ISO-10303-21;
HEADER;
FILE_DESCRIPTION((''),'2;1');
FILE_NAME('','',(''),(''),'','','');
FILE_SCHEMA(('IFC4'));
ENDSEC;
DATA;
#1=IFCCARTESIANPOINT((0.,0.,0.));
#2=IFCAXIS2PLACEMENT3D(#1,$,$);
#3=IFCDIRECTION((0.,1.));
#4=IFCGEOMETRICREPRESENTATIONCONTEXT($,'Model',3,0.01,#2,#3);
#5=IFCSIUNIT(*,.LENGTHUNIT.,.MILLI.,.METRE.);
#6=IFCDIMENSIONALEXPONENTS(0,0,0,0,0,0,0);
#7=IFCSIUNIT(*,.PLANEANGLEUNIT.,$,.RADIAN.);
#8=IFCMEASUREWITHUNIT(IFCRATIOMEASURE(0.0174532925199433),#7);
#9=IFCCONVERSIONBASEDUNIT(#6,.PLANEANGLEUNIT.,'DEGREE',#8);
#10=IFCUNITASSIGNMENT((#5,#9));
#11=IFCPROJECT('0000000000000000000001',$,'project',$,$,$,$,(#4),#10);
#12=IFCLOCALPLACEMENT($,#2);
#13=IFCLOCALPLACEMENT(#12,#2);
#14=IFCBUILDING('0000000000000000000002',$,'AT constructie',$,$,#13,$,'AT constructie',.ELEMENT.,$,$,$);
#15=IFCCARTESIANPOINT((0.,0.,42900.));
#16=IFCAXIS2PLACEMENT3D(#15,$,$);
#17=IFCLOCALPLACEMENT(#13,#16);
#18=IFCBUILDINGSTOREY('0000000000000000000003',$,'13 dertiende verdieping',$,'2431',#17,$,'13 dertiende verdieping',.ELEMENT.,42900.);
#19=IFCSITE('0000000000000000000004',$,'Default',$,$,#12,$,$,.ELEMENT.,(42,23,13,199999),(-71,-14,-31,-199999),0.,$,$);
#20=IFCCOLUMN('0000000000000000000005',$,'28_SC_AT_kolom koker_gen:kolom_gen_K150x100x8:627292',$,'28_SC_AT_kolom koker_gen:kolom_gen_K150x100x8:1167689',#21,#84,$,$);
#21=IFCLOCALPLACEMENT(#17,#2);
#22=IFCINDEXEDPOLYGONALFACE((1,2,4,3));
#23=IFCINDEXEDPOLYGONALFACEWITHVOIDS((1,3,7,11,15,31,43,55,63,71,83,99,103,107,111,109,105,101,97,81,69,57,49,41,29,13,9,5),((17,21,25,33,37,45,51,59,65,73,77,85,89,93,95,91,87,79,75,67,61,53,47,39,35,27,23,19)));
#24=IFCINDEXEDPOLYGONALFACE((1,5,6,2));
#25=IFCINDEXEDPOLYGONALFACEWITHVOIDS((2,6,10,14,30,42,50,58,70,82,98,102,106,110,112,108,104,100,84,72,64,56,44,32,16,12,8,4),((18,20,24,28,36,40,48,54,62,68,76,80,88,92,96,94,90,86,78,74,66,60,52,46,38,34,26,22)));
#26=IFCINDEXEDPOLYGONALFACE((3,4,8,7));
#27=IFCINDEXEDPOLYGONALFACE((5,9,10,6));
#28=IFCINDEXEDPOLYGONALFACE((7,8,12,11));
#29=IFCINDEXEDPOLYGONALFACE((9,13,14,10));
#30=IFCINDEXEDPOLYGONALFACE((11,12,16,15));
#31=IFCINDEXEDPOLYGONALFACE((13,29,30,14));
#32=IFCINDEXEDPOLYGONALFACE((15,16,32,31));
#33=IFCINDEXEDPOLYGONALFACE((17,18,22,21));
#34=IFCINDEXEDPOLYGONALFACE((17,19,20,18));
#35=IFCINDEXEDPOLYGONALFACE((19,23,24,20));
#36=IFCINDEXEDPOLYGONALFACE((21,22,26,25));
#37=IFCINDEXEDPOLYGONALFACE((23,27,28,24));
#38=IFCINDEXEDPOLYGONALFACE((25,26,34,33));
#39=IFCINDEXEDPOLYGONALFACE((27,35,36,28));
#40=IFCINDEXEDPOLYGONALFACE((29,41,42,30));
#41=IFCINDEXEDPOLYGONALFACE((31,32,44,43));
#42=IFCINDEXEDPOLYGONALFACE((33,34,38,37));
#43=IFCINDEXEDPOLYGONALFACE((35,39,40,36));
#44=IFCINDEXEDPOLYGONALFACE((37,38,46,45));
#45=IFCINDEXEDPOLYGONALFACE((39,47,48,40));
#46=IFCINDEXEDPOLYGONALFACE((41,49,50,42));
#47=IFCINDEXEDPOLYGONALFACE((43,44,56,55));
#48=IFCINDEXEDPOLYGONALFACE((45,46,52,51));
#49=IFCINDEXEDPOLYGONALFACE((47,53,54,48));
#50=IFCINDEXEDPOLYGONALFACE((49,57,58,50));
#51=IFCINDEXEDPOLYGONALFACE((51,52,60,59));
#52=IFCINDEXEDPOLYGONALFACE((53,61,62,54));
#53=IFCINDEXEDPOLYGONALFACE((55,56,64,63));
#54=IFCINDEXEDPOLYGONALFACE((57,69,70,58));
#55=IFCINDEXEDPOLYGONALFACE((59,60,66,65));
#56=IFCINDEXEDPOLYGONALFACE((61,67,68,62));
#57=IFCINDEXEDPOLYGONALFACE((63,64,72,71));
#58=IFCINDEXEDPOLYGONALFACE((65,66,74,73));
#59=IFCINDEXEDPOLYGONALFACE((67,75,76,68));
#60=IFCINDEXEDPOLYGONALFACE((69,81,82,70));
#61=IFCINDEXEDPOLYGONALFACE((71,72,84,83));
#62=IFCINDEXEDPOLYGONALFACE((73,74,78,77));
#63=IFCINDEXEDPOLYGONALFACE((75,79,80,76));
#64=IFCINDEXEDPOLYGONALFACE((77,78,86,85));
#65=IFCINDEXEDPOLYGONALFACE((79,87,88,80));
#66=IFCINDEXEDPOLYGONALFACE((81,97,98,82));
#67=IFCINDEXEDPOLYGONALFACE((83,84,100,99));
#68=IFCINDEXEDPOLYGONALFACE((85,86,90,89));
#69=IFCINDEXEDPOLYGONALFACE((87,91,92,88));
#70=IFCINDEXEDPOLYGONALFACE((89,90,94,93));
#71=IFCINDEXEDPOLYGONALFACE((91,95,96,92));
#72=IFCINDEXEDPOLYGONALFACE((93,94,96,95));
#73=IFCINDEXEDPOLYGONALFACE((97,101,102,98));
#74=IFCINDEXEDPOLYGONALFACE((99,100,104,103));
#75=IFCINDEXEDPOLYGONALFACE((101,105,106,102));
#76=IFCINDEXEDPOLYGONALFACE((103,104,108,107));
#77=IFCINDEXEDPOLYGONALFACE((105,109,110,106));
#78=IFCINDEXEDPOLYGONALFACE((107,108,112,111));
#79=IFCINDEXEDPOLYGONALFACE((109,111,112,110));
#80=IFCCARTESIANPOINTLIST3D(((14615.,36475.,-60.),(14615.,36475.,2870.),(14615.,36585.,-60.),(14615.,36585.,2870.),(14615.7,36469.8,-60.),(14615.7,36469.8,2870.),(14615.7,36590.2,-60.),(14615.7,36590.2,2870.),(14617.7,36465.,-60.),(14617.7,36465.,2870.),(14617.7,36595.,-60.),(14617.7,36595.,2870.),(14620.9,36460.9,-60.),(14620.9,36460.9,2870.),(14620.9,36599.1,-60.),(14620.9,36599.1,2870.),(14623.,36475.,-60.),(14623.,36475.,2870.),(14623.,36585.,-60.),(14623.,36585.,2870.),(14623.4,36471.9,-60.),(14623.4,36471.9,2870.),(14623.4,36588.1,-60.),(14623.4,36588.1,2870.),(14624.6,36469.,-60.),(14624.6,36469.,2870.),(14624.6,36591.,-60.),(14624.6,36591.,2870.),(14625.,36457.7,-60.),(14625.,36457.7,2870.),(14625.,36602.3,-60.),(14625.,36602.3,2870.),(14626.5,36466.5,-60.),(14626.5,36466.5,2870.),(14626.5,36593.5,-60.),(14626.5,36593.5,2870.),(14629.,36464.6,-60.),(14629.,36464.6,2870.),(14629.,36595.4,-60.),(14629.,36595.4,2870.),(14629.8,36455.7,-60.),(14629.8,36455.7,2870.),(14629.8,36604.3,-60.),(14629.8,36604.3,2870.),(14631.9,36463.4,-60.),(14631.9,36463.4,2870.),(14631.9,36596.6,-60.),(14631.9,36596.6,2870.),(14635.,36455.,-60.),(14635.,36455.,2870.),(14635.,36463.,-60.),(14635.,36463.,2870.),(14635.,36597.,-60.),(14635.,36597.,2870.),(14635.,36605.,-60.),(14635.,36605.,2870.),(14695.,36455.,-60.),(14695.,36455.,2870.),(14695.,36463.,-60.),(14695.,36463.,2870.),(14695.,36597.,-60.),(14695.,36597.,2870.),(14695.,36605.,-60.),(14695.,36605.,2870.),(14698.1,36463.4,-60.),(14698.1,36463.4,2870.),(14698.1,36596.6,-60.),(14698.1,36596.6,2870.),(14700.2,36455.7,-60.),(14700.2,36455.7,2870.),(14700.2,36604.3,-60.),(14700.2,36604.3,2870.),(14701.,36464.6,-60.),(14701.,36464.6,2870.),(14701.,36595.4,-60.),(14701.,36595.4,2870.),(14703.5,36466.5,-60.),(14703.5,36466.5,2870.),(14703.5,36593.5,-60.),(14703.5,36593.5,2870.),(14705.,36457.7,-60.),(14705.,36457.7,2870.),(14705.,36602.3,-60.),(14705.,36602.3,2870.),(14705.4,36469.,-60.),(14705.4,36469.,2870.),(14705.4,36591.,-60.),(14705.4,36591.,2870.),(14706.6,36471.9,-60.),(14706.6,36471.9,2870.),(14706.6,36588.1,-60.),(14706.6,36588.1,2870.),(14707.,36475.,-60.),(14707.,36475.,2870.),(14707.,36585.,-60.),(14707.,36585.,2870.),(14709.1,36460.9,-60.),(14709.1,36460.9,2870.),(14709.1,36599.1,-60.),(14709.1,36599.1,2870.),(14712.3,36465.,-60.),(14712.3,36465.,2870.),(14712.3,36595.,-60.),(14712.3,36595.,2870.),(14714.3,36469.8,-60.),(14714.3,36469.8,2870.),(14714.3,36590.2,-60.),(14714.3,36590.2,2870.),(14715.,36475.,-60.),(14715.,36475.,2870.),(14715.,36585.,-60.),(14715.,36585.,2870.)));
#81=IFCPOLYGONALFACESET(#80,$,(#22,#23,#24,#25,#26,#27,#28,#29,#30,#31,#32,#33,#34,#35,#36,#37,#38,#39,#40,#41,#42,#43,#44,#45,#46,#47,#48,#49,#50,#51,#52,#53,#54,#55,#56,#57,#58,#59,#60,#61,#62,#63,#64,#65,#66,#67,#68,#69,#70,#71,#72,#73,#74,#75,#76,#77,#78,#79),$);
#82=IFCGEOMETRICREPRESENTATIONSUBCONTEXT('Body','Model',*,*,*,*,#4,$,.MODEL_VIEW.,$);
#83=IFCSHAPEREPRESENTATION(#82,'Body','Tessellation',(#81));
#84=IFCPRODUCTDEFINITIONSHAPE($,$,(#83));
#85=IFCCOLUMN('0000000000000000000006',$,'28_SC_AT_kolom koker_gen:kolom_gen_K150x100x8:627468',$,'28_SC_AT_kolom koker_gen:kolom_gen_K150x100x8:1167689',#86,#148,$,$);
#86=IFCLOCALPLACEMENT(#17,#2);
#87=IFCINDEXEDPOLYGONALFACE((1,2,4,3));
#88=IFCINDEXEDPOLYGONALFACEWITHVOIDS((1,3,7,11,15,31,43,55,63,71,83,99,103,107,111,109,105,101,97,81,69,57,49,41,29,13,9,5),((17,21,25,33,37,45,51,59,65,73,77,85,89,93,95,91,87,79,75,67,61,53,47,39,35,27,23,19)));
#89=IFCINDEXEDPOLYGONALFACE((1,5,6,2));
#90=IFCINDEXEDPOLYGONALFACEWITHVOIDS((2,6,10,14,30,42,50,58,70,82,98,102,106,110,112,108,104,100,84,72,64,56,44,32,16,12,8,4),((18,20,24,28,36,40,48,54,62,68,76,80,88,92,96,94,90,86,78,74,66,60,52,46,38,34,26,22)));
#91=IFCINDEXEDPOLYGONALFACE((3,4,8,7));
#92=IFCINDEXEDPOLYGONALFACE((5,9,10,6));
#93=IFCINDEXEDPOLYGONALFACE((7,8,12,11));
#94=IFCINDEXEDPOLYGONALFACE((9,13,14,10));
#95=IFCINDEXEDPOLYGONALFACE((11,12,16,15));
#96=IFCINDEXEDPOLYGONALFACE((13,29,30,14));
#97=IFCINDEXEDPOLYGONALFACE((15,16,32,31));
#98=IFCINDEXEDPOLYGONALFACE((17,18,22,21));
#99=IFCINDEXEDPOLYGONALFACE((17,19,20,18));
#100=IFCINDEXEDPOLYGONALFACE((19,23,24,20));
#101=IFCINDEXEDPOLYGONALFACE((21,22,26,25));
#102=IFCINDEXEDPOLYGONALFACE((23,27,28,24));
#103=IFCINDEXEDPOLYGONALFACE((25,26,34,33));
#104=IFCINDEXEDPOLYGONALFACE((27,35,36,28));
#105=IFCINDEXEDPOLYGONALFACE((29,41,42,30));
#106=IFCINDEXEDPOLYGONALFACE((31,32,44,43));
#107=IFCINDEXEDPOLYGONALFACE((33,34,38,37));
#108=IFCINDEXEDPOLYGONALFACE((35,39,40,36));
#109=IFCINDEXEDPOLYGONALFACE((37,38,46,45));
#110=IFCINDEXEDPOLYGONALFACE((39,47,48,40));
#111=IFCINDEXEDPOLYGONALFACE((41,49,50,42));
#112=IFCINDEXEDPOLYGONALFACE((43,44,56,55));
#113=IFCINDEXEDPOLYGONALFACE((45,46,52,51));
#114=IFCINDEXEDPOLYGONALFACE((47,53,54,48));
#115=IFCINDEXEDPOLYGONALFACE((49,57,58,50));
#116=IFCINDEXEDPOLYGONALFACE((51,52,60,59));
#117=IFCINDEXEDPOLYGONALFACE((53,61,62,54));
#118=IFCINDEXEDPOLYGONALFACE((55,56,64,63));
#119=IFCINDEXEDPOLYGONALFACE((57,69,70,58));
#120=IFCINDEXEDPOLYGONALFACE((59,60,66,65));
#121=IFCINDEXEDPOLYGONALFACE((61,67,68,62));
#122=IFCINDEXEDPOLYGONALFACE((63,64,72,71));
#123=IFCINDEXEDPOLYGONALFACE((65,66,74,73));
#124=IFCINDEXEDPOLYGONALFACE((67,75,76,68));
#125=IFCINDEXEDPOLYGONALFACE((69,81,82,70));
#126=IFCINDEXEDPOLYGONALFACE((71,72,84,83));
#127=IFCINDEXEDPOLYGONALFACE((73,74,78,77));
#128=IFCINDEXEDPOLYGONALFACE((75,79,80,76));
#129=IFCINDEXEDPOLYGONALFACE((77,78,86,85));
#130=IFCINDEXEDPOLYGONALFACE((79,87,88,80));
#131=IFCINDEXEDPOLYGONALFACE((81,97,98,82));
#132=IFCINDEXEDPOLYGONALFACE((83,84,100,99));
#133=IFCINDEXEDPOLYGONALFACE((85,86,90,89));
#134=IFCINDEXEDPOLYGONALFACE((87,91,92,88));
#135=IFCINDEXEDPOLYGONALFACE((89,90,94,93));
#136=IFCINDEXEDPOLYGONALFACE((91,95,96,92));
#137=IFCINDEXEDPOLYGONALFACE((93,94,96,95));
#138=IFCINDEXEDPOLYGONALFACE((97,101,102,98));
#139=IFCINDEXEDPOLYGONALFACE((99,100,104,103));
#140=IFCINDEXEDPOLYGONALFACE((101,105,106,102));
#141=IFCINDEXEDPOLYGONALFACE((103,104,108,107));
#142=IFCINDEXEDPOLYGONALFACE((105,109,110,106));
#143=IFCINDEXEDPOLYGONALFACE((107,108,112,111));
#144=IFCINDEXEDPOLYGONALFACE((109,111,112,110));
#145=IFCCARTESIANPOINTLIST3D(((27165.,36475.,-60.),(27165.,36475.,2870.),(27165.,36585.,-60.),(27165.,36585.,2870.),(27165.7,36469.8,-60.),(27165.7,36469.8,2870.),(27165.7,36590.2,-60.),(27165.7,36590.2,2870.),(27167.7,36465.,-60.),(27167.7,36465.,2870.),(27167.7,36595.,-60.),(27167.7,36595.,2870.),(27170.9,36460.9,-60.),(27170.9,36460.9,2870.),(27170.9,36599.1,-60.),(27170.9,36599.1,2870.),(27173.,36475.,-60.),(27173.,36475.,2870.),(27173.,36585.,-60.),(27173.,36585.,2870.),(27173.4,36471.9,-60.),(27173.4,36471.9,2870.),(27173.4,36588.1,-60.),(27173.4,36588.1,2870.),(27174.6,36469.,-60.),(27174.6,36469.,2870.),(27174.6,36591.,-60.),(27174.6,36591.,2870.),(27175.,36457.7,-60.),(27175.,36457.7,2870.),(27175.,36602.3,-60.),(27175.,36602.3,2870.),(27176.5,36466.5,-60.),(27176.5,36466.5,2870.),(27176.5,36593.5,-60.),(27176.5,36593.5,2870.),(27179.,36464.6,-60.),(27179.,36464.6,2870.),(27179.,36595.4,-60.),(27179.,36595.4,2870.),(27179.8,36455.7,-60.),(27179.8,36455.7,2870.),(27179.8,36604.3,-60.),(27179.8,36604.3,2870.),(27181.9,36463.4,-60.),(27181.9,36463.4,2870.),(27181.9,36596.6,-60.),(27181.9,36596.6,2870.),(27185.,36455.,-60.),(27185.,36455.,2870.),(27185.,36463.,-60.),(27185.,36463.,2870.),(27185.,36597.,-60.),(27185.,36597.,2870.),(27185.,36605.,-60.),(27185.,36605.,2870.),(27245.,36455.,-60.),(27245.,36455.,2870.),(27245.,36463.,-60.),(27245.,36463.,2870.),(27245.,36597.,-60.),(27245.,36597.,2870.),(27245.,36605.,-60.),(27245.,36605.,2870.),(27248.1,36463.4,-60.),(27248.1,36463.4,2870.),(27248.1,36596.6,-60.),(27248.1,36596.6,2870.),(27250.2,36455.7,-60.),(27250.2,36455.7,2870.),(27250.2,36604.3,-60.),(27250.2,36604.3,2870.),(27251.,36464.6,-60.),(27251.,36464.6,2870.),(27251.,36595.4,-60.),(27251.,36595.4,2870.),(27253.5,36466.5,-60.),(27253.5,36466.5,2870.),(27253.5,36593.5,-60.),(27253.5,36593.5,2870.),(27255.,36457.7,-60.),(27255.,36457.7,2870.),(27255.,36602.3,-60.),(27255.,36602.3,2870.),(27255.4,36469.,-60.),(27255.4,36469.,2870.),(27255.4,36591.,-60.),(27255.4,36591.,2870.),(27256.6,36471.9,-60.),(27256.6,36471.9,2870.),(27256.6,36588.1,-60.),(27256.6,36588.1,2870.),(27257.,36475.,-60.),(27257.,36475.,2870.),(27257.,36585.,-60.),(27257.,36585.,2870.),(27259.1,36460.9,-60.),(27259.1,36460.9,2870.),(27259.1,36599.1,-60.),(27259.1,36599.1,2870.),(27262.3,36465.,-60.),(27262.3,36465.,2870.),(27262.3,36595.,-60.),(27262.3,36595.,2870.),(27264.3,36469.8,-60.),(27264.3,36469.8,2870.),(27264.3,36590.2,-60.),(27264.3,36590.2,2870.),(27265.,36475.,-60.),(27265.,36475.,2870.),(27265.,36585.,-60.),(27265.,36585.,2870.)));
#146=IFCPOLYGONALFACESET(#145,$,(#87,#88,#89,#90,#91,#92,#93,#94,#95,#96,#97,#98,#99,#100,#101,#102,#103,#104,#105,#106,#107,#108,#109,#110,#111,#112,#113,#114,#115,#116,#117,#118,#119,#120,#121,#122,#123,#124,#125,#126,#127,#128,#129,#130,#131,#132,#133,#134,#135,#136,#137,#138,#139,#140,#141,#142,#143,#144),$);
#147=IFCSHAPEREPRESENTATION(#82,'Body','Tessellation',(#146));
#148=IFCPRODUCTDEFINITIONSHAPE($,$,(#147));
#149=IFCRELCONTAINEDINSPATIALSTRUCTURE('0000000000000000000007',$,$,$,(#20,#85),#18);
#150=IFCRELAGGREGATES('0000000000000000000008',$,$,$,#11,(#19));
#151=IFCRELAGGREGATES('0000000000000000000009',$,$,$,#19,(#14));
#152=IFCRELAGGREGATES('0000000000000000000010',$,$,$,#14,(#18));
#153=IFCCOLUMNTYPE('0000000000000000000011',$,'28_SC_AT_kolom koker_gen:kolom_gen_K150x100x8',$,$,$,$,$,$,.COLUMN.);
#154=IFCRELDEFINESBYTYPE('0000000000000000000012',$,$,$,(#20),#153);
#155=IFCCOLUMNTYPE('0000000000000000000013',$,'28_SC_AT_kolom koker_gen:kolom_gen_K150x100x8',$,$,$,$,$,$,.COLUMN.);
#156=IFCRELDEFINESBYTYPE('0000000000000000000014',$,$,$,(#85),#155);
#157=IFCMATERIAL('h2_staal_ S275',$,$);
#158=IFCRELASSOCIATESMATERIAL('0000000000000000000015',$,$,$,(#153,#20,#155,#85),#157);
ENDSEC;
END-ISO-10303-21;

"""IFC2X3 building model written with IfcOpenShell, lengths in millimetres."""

from ifc_helpers import new_model, entity, si_unit, converted_unit, direction, frame, frame_2d, origin, place, context, subcontext, project, spatial, polyline, circle_curve, parameter, trimmed, segment, composite_curve, outline, extrude, source, transform, mapped, material, type_object, type_shapes, element, save


model = new_model("IFC2X3")

# Units and contexts
model_context = context("Model", 3, precision=0.01, world=origin(), true_north=direction((0.0, 1.0)))
body_context = subcontext(model_context, "Body", "Model", "MODEL_VIEW")
ifc_project = project(units=[si_unit("LENGTHUNIT", "METRE", prefix="MILLI"), converted_unit("PLANEANGLEUNIT", "DEGREE", entity("IfcRatioMeasure", 0.0174532925199433), si_unit("PLANEANGLEUNIT", "RADIAN"), dimensions=[0, 0, 0, 0, 0, 0, 0])], contexts=[model_context])

# Site, building, storey
site_placement = place(None, origin())
site = spatial("IfcSite", under=ifc_project, at=site_placement, Name="Default", CompositionType="ELEMENT", RefLatitude=(42, 23, 13, 199999), RefLongitude=(-71, -14, -31, -199999), RefElevation=0.0)
building_placement = place(site_placement, origin())
building = spatial("IfcBuilding", under=site, at=building_placement, Name="AT constructie", LongName="AT constructie", CompositionType="ELEMENT")
storey_placement = place(building_placement, frame((0.0, 0.0, 42900.0)))
storey = spatial("IfcBuildingStorey", under=building, at=storey_placement, Name="13 dertiende verdieping", ObjectType="2431", LongName="13 dertiende verdieping", CompositionType="ELEMENT", Elevation=42900.0)

# Columns
ifc_material = material(Name="h2_staal_ S275")
column_type_1 = type_object("IfcColumnType", Name="28_SC_AT_kolom koker_gen:kolom_gen_K150x100x8", PredefinedType="COLUMN", material=ifc_material)
shared_shape_1 = source(origin(), body_context, "Body", "SweptSolid", [
    extrude(outline(composite_curve([segment(trimmed(circle_curve(frame_2d((30.0, 55.0), x_axis=(1.0, 0.0)), 20.0), [parameter(360.0)], [parameter(90.0)], True, "PARAMETER"), True, "CONTINUOUS"), segment(polyline([(30.0, 75.0), (-30.0, 75.0)]), True, "CONTINUOUS"), segment(trimmed(circle_curve(frame_2d((-30.0, 55.0), x_axis=(1.0, 0.0)), 20.0), [parameter(90.0)], [parameter(180.0)], True, "PARAMETER"), True, "CONTINUOUS"), segment(polyline([(-50.0, 55.0), (-50.0, -55.0)]), True, "CONTINUOUS"), segment(trimmed(circle_curve(frame_2d((-30.0, -55.0), x_axis=(1.0, 0.0)), 20.0), [parameter(180.0)], [parameter(270.0)], True, "PARAMETER"), True, "CONTINUOUS"), segment(polyline([(-30.0, -75.0), (30.0, -75.0)]), True, "CONTINUOUS"), segment(trimmed(circle_curve(frame_2d((30.0, -55.0), x_axis=(1.0, 0.0)), 20.0), [parameter(270.0)], [parameter(0.0)], True, "PARAMETER"), True, "CONTINUOUS"), segment(polyline([(50.0, -55.0), (50.0, 55.0)]), True, "CONTINUOUS")], self_intersect=False), holes=[composite_curve([segment(polyline([(-30.0, 67.0), (30.0, 67.0)]), True, "CONTINUOUS"), segment(trimmed(circle_curve(frame_2d((30.0, 55.0), x_axis=(1.0, 0.0)), 12.0), [parameter(360.0)], [parameter(90.0)], True, "PARAMETER"), False, "CONTINUOUS"), segment(polyline([(42.0, 55.0), (42.0, -55.0)]), True, "CONTINUOUS"), segment(trimmed(circle_curve(frame_2d((30.0, -55.0), x_axis=(1.0, 0.0)), 12.0), [parameter(270.0)], [parameter(360.0)], True, "PARAMETER"), False, "CONTINUOUS"), segment(polyline([(30.0, -67.0), (-30.0, -67.0)]), True, "CONTINUOUS"), segment(trimmed(circle_curve(frame_2d((-30.0, -55.0), x_axis=(1.0, 0.0)), 12.0), [parameter(180.0)], [parameter(270.0)], True, "PARAMETER"), False, "CONTINUOUS"), segment(polyline([(-42.0, -55.0), (-42.0, 55.0)]), True, "CONTINUOUS"), segment(trimmed(circle_curve(frame_2d((-30.0, 55.0), x_axis=(1.0, 0.0)), 12.0), [parameter(90.0)], [parameter(180.0)], True, "PARAMETER"), False, "CONTINUOUS")], self_intersect=False)]), frame((14665.0, 36530.0, 42840.0)), (0.0, 0.0, 1.0), 2930.0),
])
type_shapes(column_type_1, [shared_shape_1])
column_1_placement = place(storey_placement, frame((0.0, 0.0, -42900.0)))
element("IfcColumn", 1, at=column_1_placement, inside=storey, type_object=column_type_1, material=ifc_material, Name="28_SC_AT_kolom koker_gen:kolom_gen_K150x100x8:627292", ObjectType="28_SC_AT_kolom koker_gen:kolom_gen_K150x100x8:1167689", context=body_context, shape_type="MappedRepresentation", body=[
    mapped(shared_shape_1, transform((0.0, 0.0, 0.0), scale=1.0)),
])
column_type_2 = type_object("IfcColumnType", Name="28_SC_AT_kolom koker_gen:kolom_gen_K150x100x8", PredefinedType="COLUMN", material=ifc_material)
shared_shape_2 = source(origin(), body_context, "Body", "SweptSolid", [
    extrude(outline(composite_curve([segment(trimmed(circle_curve(frame_2d((30.0, 55.0), x_axis=(1.0, 0.0)), 20.0), [parameter(360.0)], [parameter(90.0)], True, "PARAMETER"), True, "CONTINUOUS"), segment(polyline([(30.0, 75.0), (-30.0, 75.0)]), True, "CONTINUOUS"), segment(trimmed(circle_curve(frame_2d((-30.0, 55.0), x_axis=(1.0, 0.0)), 20.0), [parameter(90.0)], [parameter(180.0)], True, "PARAMETER"), True, "CONTINUOUS"), segment(polyline([(-50.0, 55.0), (-50.0, -55.0)]), True, "CONTINUOUS"), segment(trimmed(circle_curve(frame_2d((-30.0, -55.0), x_axis=(1.0, 0.0)), 20.0), [parameter(180.0)], [parameter(270.0)], True, "PARAMETER"), True, "CONTINUOUS"), segment(polyline([(-30.0, -75.0), (30.0, -75.0)]), True, "CONTINUOUS"), segment(trimmed(circle_curve(frame_2d((30.0, -55.0), x_axis=(1.0, 0.0)), 20.0), [parameter(270.0)], [parameter(0.0)], True, "PARAMETER"), True, "CONTINUOUS"), segment(polyline([(50.0, -55.0), (50.0, 55.0)]), True, "CONTINUOUS")], self_intersect=False), holes=[composite_curve([segment(polyline([(-30.0, 67.0), (30.0, 67.0)]), True, "CONTINUOUS"), segment(trimmed(circle_curve(frame_2d((30.0, 55.0), x_axis=(1.0, 0.0)), 12.0), [parameter(360.0)], [parameter(90.0)], True, "PARAMETER"), False, "CONTINUOUS"), segment(polyline([(42.0, 55.0), (42.0, -55.0)]), True, "CONTINUOUS"), segment(trimmed(circle_curve(frame_2d((30.0, -55.0), x_axis=(1.0, 0.0)), 12.0), [parameter(270.0)], [parameter(360.0)], True, "PARAMETER"), False, "CONTINUOUS"), segment(polyline([(30.0, -67.0), (-30.0, -67.0)]), True, "CONTINUOUS"), segment(trimmed(circle_curve(frame_2d((-30.0, -55.0), x_axis=(1.0, 0.0)), 12.0), [parameter(180.0)], [parameter(270.0)], True, "PARAMETER"), False, "CONTINUOUS"), segment(polyline([(-42.0, -55.0), (-42.0, 55.0)]), True, "CONTINUOUS"), segment(trimmed(circle_curve(frame_2d((-30.0, 55.0), x_axis=(1.0, 0.0)), 12.0), [parameter(90.0)], [parameter(180.0)], True, "PARAMETER"), False, "CONTINUOUS")], self_intersect=False)]), frame((27215.0, 36530.0, 42840.0)), (0.0, 0.0, 1.0), 2930.0),
])
type_shapes(column_type_2, [shared_shape_2])
column_2_placement = place(storey_placement, frame((0.0, 0.0, -42900.0)))
element("IfcColumn", 2, at=column_2_placement, inside=storey, type_object=column_type_2, material=ifc_material, Name="28_SC_AT_kolom koker_gen:kolom_gen_K150x100x8:627468", ObjectType="28_SC_AT_kolom koker_gen:kolom_gen_K150x100x8:1167689", context=body_context, shape_type="MappedRepresentation", body=[
    mapped(shared_shape_2, transform((0.0, 0.0, 0.0), scale=1.0)),
])

save(model, "model.ifc")
